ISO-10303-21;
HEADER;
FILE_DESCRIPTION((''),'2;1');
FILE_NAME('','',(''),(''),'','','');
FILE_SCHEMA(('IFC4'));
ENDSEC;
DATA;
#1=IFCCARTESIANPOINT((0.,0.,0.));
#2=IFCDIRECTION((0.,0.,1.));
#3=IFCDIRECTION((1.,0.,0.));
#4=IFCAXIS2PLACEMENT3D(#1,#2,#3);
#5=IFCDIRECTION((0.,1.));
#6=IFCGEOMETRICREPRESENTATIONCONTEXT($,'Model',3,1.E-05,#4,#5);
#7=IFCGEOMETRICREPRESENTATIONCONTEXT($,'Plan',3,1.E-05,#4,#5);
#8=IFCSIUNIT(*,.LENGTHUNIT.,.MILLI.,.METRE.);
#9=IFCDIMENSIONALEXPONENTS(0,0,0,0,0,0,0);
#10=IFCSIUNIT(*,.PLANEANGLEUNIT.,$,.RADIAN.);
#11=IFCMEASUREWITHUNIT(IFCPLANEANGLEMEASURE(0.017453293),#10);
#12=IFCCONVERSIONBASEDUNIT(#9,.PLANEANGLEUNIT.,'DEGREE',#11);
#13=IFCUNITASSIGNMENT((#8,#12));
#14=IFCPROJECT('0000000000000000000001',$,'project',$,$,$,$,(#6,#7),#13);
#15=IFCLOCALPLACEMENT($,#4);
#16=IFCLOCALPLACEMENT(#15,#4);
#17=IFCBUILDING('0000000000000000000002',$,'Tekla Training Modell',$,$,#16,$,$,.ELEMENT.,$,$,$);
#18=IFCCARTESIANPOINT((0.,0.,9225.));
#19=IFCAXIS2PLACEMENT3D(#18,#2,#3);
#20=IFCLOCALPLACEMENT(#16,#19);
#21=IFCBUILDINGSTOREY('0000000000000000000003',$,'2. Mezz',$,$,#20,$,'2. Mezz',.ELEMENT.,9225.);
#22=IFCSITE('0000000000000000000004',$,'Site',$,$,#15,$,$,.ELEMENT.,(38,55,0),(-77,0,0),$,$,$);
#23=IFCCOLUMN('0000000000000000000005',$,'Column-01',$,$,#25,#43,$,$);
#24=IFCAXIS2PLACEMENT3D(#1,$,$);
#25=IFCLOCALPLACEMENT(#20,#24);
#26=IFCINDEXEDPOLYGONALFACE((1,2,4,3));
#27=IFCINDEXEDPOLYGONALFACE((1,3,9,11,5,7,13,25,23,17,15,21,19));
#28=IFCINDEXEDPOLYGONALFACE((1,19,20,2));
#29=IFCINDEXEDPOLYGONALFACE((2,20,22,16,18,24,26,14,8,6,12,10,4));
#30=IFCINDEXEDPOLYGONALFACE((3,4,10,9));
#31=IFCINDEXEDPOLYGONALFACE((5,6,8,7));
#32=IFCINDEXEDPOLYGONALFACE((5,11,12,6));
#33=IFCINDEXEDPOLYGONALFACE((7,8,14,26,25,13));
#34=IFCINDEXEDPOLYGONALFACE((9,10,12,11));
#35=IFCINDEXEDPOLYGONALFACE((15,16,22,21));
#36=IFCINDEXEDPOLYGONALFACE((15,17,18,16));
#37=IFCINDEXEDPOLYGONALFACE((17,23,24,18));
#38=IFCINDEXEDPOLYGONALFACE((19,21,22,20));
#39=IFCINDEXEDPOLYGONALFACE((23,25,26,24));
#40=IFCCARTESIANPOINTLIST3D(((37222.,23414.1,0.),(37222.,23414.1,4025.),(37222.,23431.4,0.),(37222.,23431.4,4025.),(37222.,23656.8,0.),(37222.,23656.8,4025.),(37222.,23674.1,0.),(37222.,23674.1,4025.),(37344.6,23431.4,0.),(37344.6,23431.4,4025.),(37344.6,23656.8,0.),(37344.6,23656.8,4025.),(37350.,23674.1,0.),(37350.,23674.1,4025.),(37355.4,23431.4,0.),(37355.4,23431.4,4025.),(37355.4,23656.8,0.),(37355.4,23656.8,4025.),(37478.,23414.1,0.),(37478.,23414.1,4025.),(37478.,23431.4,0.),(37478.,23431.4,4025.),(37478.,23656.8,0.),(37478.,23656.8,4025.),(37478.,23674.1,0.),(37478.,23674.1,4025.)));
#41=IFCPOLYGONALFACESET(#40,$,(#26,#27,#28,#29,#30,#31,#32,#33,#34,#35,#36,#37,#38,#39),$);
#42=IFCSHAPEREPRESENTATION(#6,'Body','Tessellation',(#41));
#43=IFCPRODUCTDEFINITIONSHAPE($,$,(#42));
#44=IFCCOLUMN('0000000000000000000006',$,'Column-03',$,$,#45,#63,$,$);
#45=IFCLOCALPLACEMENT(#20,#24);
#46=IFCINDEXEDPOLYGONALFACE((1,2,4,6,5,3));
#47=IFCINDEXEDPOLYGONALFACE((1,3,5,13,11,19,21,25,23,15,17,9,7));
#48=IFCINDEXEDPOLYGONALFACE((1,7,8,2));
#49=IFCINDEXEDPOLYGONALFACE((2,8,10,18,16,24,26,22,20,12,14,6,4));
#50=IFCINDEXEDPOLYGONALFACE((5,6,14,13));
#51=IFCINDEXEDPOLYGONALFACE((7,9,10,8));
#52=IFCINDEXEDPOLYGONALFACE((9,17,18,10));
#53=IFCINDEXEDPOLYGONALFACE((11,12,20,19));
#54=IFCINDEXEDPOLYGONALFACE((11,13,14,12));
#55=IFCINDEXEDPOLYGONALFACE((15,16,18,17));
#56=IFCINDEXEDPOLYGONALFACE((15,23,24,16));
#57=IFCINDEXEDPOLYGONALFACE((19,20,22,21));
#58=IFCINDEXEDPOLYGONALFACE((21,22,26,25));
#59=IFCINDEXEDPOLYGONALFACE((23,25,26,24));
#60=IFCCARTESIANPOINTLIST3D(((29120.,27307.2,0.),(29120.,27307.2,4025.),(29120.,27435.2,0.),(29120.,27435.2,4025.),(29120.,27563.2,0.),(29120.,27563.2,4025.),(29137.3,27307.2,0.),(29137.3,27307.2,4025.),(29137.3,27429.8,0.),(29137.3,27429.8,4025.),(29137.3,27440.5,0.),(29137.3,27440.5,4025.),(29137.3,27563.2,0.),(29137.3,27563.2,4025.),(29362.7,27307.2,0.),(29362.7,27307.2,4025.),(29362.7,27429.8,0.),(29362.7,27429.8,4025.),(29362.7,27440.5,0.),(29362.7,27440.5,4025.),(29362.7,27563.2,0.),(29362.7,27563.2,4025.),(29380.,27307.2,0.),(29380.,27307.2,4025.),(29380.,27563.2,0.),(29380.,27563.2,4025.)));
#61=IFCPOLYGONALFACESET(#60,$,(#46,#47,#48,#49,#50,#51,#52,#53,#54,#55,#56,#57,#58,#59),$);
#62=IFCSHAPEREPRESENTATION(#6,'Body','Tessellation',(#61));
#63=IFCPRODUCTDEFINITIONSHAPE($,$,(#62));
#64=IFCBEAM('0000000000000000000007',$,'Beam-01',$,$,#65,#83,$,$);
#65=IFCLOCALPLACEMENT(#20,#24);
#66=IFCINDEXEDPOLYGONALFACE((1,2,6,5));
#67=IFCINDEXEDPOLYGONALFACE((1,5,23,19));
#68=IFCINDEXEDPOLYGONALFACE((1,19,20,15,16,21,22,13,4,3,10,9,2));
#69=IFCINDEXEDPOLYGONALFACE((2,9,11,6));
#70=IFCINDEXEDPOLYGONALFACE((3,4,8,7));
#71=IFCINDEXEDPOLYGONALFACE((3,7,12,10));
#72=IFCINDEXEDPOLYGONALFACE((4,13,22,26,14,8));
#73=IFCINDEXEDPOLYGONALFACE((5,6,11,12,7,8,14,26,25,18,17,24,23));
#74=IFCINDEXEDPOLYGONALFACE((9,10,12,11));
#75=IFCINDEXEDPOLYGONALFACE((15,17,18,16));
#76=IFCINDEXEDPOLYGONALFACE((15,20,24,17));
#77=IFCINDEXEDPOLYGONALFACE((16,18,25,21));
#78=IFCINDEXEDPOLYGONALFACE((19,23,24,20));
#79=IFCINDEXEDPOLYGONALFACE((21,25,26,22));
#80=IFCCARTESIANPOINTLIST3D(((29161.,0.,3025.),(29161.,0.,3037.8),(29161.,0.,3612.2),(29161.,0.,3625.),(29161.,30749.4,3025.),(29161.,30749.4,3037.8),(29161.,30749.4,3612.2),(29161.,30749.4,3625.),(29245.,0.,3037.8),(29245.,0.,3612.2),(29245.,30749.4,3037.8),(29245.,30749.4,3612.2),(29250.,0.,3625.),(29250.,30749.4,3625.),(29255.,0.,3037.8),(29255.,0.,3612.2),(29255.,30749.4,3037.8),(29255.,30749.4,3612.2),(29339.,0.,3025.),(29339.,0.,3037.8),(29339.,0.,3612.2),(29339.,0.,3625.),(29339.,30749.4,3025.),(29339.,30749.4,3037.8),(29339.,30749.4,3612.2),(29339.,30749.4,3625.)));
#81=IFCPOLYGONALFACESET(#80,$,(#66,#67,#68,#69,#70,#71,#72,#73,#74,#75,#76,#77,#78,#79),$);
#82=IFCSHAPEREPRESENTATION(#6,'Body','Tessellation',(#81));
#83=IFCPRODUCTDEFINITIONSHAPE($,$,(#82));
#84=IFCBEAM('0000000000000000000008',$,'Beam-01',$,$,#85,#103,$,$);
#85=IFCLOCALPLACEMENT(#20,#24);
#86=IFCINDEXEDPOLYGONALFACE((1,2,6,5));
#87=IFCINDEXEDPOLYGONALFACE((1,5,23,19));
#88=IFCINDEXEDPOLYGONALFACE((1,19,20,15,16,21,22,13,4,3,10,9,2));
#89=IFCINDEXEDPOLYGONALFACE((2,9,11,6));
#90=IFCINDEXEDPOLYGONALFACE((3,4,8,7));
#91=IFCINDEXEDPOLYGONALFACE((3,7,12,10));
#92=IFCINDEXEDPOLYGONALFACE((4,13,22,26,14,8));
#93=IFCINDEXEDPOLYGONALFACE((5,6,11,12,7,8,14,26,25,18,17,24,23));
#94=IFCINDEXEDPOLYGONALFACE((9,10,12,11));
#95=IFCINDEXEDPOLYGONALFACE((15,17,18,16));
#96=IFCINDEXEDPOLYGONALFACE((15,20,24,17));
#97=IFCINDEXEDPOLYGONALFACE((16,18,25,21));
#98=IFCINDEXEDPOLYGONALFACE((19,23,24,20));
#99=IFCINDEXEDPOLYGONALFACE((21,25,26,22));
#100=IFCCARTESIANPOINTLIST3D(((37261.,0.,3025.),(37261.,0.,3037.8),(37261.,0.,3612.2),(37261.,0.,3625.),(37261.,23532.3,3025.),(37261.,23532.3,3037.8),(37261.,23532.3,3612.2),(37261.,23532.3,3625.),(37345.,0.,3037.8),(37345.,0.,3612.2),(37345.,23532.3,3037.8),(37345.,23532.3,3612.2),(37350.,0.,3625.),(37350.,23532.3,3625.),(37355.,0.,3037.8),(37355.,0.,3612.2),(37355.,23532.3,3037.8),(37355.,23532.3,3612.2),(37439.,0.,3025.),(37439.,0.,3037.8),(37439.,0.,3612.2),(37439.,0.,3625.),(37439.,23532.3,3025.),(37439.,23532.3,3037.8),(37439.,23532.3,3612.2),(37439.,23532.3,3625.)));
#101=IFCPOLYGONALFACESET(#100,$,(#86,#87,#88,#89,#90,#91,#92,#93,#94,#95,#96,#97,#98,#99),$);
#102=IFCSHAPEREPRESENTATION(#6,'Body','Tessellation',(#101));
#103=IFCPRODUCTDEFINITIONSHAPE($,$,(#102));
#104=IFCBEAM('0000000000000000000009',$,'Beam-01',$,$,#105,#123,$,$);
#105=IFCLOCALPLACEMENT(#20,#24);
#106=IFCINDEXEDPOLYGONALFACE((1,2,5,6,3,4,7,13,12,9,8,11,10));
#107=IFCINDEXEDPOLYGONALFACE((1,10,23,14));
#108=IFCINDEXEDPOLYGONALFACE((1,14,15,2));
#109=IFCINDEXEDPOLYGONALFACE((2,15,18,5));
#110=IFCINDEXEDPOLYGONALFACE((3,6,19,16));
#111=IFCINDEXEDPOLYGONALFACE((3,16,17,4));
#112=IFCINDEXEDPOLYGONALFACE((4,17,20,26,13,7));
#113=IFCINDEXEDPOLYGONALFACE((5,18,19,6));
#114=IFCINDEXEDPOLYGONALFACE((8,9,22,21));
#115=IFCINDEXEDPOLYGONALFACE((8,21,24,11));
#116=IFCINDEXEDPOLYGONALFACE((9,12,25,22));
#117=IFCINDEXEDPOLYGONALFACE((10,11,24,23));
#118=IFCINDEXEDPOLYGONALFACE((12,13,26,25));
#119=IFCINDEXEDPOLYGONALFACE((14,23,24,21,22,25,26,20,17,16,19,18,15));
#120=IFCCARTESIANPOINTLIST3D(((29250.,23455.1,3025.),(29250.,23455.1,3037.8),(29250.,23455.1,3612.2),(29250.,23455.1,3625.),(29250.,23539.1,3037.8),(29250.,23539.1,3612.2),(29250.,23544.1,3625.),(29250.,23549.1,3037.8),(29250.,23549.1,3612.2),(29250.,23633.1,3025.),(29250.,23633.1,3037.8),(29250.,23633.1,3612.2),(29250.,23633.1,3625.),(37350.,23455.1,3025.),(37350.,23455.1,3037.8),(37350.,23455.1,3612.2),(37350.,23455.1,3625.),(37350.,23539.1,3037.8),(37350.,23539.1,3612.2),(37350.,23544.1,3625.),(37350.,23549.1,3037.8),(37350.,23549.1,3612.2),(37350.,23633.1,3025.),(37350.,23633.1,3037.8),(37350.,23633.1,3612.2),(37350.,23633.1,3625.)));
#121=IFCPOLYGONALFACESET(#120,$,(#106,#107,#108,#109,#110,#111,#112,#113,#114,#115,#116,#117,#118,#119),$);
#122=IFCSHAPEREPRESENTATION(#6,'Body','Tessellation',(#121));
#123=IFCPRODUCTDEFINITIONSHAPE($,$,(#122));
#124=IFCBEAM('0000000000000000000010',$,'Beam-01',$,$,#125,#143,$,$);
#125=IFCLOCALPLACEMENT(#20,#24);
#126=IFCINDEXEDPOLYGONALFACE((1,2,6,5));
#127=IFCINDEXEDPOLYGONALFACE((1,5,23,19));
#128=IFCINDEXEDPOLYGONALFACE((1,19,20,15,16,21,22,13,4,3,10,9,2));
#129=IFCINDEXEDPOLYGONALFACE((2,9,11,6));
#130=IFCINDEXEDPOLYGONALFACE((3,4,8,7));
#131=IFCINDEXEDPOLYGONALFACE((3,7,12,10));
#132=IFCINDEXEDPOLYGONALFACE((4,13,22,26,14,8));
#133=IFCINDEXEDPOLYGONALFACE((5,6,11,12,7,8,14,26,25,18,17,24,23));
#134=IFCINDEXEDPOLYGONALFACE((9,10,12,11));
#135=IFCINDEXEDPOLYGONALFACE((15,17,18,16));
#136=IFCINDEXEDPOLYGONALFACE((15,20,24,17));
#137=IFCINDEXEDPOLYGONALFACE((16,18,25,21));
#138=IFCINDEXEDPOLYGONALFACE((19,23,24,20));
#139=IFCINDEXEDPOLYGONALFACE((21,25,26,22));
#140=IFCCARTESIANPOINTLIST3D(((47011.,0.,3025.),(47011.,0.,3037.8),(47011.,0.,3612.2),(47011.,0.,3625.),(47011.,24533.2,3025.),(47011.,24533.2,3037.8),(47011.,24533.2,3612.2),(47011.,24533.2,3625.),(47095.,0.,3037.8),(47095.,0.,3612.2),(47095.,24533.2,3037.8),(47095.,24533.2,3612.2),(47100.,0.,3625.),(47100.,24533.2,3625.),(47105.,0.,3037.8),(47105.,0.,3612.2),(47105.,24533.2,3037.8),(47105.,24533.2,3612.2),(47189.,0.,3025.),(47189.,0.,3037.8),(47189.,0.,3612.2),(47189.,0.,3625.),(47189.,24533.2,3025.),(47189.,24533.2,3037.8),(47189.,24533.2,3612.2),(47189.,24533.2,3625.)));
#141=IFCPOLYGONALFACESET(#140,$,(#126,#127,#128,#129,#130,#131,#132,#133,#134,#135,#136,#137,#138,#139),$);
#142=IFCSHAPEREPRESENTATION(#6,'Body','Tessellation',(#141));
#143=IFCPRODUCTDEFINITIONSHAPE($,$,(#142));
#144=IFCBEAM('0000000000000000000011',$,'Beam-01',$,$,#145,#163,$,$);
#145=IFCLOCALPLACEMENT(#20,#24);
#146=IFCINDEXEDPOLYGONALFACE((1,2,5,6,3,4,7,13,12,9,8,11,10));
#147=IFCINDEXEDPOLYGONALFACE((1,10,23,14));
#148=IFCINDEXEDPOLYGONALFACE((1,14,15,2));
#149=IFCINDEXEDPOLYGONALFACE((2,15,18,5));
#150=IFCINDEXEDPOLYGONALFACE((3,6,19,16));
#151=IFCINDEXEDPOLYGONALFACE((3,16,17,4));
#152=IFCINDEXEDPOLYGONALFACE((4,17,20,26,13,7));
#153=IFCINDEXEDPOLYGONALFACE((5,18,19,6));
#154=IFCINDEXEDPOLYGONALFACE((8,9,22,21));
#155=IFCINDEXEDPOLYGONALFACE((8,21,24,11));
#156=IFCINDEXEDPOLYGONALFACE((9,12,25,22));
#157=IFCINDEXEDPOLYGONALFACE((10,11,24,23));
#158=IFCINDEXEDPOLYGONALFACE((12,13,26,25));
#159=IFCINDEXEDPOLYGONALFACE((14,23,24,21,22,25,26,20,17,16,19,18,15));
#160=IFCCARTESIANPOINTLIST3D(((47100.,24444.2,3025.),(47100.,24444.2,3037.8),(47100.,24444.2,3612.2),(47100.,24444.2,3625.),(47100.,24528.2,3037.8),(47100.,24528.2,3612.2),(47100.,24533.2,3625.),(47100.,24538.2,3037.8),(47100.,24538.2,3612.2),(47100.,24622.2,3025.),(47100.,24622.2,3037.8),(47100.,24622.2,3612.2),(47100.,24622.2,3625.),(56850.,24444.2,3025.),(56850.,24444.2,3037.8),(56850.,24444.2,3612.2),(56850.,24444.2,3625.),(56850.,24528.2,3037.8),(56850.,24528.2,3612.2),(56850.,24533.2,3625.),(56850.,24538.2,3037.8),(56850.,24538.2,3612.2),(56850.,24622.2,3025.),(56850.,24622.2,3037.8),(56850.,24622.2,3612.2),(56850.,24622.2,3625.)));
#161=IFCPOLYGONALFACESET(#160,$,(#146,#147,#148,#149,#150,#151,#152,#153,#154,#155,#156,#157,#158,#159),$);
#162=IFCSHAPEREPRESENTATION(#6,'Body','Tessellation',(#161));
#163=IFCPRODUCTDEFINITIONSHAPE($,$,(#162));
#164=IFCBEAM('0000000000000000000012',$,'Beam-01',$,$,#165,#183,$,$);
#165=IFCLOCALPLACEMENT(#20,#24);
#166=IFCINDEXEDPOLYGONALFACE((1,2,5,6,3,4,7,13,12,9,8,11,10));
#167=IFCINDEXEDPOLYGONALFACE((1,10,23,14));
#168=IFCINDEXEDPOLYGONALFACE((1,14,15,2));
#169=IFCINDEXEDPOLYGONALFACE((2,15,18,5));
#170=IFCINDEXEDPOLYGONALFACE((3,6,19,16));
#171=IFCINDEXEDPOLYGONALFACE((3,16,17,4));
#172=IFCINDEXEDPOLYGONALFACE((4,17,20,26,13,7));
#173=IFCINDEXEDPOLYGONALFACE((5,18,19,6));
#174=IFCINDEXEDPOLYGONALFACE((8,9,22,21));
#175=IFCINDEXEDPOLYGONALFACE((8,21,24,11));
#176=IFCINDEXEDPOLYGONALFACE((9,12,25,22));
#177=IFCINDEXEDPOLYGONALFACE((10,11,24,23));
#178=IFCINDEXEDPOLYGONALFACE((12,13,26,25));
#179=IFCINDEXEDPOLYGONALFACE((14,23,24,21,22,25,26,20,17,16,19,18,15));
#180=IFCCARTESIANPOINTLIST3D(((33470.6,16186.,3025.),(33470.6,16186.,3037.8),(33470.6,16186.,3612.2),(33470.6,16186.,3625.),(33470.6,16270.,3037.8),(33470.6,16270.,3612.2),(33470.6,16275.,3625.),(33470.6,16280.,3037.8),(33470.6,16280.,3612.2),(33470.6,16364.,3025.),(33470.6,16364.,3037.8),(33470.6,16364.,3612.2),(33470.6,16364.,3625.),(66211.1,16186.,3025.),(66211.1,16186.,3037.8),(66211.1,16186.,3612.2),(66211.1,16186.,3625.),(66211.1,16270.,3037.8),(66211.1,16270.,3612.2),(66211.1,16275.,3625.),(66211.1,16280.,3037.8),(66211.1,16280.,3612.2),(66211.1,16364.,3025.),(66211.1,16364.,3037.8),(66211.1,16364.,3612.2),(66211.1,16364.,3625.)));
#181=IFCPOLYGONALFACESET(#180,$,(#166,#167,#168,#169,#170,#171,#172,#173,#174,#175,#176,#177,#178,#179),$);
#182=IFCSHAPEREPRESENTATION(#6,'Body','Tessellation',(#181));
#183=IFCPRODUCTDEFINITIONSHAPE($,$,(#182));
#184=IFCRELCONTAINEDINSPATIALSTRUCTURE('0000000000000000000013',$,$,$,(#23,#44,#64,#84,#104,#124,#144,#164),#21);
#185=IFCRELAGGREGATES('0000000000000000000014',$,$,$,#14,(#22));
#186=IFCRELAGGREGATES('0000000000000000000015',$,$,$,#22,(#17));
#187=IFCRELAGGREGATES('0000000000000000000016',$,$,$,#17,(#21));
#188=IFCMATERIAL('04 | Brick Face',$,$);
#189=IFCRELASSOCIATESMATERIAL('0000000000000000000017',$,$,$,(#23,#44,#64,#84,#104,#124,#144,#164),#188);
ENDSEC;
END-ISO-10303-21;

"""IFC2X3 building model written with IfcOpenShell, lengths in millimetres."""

from ifc_helpers import new_model, entity, si_unit, converted_unit, direction, frame, origin_with_axes, place, context, project, spatial, polyline, outline, extrude, material, element, save


model = new_model("IFC2X3")

# Units and contexts
model_context = context("Model", 3, precision=1e-05, world=origin_with_axes(), true_north=direction((0.0, 1.0)))
plan_context = context("Plan", 3, precision=1e-05, world=origin_with_axes(), true_north=direction((0.0, 1.0)))
ifc_project = project(units=[si_unit("LENGTHUNIT", "METRE", prefix="MILLI"), converted_unit("PLANEANGLEUNIT", "DEGREE", entity("IfcPlaneAngleMeasure", 0.017453293), si_unit("PLANEANGLEUNIT", "RADIAN"), dimensions=[0, 0, 0, 0, 0, 0, 0])], contexts=[model_context, plan_context])

# Site, building, storey
site_placement = place(None, origin_with_axes())
site = spatial("IfcSite", under=ifc_project, at=site_placement, Name="Site", CompositionType="ELEMENT", RefLatitude=(38, 55, 0), RefLongitude=(-77, 0, 0))
building_placement = place(site_placement, origin_with_axes())
building = spatial("IfcBuilding", under=site, at=building_placement, Name="Tekla Training Modell", CompositionType="ELEMENT")
storey_placement = place(building_placement, frame((0.0, 0.0, 9225.0), z_axis=(0.0, 0.0, 1.0), x_axis=(1.0, 0.0, 0.0)))
storey = spatial("IfcBuildingStorey", under=building, at=storey_placement, Name="2. Mezz", LongName="2. Mezz", CompositionType="ELEMENT", Elevation=9225.0)

# Columns
ifc_material_1 = material(Name="04 | Brick Face")
for number, where, z_axis, x_axis, name in (
    (1, (37350.0, 23544.1, 0.0), (0.0, 0.0, 1.0), (1.0, 0.0, 0.0), "Column-01"),
    (2, (29250.0, 27435.2, 0.0), (0.0, 0.0, 1.0), (0.0, 1.0, 0.0), "Column-03"),
):
    element("IfcColumn", number, at=place(storey_placement, frame(where, z_axis=z_axis, x_axis=x_axis)), inside=storey, material=ifc_material_1, Name=name, context=model_context, shape_type="SweptSolid", body=[
        extrude(outline(polyline([(0.0, 130.0), (-128.0, 130.0), (-128.0, 112.7), (-5.3, 112.7), (-5.3, -112.7), (-128.0, -112.7), (-128.0, -130.0), (128.0, -130.0), (128.0, -112.7), (5.3, -112.7), (5.3, 112.7), (128.0, 112.7), (128.0, 130.0), (0.0, 130.0)])), origin_with_axes(), (0.0, 0.0, 1.0), 4025.0),
    ])

# Beams
beam_1_placement = place(storey_placement, frame((29250.0, 30749.4, 3325.0), z_axis=(0.0, 0.0, 1.0), x_axis=(-1.0, 0.0, 0.0)))
element("IfcBeam", 3, at=beam_1_placement, inside=storey, material=ifc_material_1, Name="Beam-01", context=model_context, shape_type="SweptSolid", body=[
    extrude(outline(polyline([(0.0, 300.0), (-89.0, 300.0), (-89.0, 287.2), (-5.0, 287.2), (-5.0, -287.2), (-89.0, -287.2), (-89.0, -300.0), (89.0, -300.0), (89.0, -287.2), (5.0, -287.2), (5.0, 287.2), (89.0, 287.2), (89.0, 300.0), (0.0, 300.0)])), frame((0.0, 30749.4, 0.0), z_axis=(0.0, -1.0, 0.0), x_axis=(1.0, 0.0, 0.0)), (0.0, 0.0, 1.0), 30749.4),
])
beam_2_placement = place(storey_placement, frame((37350.0, 23532.3, 3325.0), z_axis=(0.0, 0.0, 1.0), x_axis=(-1.0, 0.0, 0.0)))
element("IfcBeam", 4, at=beam_2_placement, inside=storey, material=ifc_material_1, Name="Beam-01", context=model_context, shape_type="SweptSolid", body=[
    extrude(outline(polyline([(0.0, 300.0), (-89.0, 300.0), (-89.0, 287.2), (-5.0, 287.2), (-5.0, -287.2), (-89.0, -287.2), (-89.0, -300.0), (89.0, -300.0), (89.0, -287.2), (5.0, -287.2), (5.0, 287.2), (89.0, 287.2), (89.0, 300.0), (0.0, 300.0)])), frame((0.0, 23532.3, 0.0), z_axis=(0.0, -1.0, 0.0), x_axis=(1.0, 0.0, 0.0)), (0.0, 0.0, 1.0), 23532.3),
])
beam_3_placement = place(storey_placement, frame((29250.0, 23544.1, 3325.0), z_axis=(0.0, 0.0, 1.0), x_axis=(0.0, -1.0, 0.0)))
element("IfcBeam", 5, at=beam_3_placement, inside=storey, material=ifc_material_1, Name="Beam-01", context=model_context, shape_type="SweptSolid", body=[
    extrude(outline(polyline([(0.0, 300.0), (-89.0, 300.0), (-89.0, 287.2), (-5.0, 287.2), (-5.0, -287.2), (-89.0, -287.2), (-89.0, -300.0), (89.0, -300.0), (89.0, -287.2), (5.0, -287.2), (5.0, 287.2), (89.0, 287.2), (89.0, 300.0), (0.0, 300.0)])), frame((0.0, 8100.0, 0.0), z_axis=(0.0, -1.0, 0.0), x_axis=(1.0, 0.0, 0.0)), (0.0, 0.0, 1.0), 8100.0),
])
beam_4_placement = place(storey_placement, frame((47100.0, 24533.2, 3325.0), z_axis=(0.0, 0.0, 1.0), x_axis=(-1.0, 0.0, 0.0)))
element("IfcBeam", 6, at=beam_4_placement, inside=storey, material=ifc_material_1, Name="Beam-01", context=model_context, shape_type="SweptSolid", body=[
    extrude(outline(polyline([(0.0, 300.0), (-89.0, 300.0), (-89.0, 287.2), (-5.0, 287.2), (-5.0, -287.2), (-89.0, -287.2), (-89.0, -300.0), (89.0, -300.0), (89.0, -287.2), (5.0, -287.2), (5.0, 287.2), (89.0, 287.2), (89.0, 300.0), (0.0, 300.0)])), frame((0.0, 24533.2, 0.0), z_axis=(0.0, -1.0, 0.0), x_axis=(1.0, 0.0, 0.0)), (0.0, 0.0, 1.0), 24533.2),
])
beam_5_placement = place(storey_placement, frame((47100.0, 24533.2, 3325.0), z_axis=(0.0, 0.0, 1.0), x_axis=(0.0, -1.0, 0.0)))
element("IfcBeam", 7, at=beam_5_placement, inside=storey, material=ifc_material_1, Name="Beam-01", context=model_context, shape_type="SweptSolid", body=[
    extrude(outline(polyline([(0.0, 300.0), (-89.0, 300.0), (-89.0, 287.2), (-5.0, 287.2), (-5.0, -287.2), (-89.0, -287.2), (-89.0, -300.0), (89.0, -300.0), (89.0, -287.2), (5.0, -287.2), (5.0, 287.2), (89.0, 287.2), (89.0, 300.0), (0.0, 300.0)])), frame((0.0, 9750.0, 0.0), z_axis=(0.0, -1.0, 0.0), x_axis=(1.0, 0.0, 0.0)), (0.0, 0.0, 1.0), 9750.0),
])
beam_6_placement = place(storey_placement, frame((33470.6, 16275.0, 3325.0), z_axis=(0.0, 0.0, 1.0), x_axis=(0.0, -1.0, 0.0)))
element("IfcBeam", 8, at=beam_6_placement, inside=storey, material=ifc_material_1, Name="Beam-01", context=model_context, shape_type="SweptSolid", body=[
    extrude(outline(polyline([(0.0, 300.0), (-89.0, 300.0), (-89.0, 287.2), (-5.0, 287.2), (-5.0, -287.2), (-89.0, -287.2), (-89.0, -300.0), (89.0, -300.0), (89.0, -287.2), (5.0, -287.2), (5.0, 287.2), (89.0, 287.2), (89.0, 300.0), (0.0, 300.0)])), frame((0.0, 32740.5, 0.0), z_axis=(0.0, -1.0, 0.0), x_axis=(1.0, 0.0, 0.0)), (0.0, 0.0, 1.0), 32740.5),
])

save(model, "model.ifc")
